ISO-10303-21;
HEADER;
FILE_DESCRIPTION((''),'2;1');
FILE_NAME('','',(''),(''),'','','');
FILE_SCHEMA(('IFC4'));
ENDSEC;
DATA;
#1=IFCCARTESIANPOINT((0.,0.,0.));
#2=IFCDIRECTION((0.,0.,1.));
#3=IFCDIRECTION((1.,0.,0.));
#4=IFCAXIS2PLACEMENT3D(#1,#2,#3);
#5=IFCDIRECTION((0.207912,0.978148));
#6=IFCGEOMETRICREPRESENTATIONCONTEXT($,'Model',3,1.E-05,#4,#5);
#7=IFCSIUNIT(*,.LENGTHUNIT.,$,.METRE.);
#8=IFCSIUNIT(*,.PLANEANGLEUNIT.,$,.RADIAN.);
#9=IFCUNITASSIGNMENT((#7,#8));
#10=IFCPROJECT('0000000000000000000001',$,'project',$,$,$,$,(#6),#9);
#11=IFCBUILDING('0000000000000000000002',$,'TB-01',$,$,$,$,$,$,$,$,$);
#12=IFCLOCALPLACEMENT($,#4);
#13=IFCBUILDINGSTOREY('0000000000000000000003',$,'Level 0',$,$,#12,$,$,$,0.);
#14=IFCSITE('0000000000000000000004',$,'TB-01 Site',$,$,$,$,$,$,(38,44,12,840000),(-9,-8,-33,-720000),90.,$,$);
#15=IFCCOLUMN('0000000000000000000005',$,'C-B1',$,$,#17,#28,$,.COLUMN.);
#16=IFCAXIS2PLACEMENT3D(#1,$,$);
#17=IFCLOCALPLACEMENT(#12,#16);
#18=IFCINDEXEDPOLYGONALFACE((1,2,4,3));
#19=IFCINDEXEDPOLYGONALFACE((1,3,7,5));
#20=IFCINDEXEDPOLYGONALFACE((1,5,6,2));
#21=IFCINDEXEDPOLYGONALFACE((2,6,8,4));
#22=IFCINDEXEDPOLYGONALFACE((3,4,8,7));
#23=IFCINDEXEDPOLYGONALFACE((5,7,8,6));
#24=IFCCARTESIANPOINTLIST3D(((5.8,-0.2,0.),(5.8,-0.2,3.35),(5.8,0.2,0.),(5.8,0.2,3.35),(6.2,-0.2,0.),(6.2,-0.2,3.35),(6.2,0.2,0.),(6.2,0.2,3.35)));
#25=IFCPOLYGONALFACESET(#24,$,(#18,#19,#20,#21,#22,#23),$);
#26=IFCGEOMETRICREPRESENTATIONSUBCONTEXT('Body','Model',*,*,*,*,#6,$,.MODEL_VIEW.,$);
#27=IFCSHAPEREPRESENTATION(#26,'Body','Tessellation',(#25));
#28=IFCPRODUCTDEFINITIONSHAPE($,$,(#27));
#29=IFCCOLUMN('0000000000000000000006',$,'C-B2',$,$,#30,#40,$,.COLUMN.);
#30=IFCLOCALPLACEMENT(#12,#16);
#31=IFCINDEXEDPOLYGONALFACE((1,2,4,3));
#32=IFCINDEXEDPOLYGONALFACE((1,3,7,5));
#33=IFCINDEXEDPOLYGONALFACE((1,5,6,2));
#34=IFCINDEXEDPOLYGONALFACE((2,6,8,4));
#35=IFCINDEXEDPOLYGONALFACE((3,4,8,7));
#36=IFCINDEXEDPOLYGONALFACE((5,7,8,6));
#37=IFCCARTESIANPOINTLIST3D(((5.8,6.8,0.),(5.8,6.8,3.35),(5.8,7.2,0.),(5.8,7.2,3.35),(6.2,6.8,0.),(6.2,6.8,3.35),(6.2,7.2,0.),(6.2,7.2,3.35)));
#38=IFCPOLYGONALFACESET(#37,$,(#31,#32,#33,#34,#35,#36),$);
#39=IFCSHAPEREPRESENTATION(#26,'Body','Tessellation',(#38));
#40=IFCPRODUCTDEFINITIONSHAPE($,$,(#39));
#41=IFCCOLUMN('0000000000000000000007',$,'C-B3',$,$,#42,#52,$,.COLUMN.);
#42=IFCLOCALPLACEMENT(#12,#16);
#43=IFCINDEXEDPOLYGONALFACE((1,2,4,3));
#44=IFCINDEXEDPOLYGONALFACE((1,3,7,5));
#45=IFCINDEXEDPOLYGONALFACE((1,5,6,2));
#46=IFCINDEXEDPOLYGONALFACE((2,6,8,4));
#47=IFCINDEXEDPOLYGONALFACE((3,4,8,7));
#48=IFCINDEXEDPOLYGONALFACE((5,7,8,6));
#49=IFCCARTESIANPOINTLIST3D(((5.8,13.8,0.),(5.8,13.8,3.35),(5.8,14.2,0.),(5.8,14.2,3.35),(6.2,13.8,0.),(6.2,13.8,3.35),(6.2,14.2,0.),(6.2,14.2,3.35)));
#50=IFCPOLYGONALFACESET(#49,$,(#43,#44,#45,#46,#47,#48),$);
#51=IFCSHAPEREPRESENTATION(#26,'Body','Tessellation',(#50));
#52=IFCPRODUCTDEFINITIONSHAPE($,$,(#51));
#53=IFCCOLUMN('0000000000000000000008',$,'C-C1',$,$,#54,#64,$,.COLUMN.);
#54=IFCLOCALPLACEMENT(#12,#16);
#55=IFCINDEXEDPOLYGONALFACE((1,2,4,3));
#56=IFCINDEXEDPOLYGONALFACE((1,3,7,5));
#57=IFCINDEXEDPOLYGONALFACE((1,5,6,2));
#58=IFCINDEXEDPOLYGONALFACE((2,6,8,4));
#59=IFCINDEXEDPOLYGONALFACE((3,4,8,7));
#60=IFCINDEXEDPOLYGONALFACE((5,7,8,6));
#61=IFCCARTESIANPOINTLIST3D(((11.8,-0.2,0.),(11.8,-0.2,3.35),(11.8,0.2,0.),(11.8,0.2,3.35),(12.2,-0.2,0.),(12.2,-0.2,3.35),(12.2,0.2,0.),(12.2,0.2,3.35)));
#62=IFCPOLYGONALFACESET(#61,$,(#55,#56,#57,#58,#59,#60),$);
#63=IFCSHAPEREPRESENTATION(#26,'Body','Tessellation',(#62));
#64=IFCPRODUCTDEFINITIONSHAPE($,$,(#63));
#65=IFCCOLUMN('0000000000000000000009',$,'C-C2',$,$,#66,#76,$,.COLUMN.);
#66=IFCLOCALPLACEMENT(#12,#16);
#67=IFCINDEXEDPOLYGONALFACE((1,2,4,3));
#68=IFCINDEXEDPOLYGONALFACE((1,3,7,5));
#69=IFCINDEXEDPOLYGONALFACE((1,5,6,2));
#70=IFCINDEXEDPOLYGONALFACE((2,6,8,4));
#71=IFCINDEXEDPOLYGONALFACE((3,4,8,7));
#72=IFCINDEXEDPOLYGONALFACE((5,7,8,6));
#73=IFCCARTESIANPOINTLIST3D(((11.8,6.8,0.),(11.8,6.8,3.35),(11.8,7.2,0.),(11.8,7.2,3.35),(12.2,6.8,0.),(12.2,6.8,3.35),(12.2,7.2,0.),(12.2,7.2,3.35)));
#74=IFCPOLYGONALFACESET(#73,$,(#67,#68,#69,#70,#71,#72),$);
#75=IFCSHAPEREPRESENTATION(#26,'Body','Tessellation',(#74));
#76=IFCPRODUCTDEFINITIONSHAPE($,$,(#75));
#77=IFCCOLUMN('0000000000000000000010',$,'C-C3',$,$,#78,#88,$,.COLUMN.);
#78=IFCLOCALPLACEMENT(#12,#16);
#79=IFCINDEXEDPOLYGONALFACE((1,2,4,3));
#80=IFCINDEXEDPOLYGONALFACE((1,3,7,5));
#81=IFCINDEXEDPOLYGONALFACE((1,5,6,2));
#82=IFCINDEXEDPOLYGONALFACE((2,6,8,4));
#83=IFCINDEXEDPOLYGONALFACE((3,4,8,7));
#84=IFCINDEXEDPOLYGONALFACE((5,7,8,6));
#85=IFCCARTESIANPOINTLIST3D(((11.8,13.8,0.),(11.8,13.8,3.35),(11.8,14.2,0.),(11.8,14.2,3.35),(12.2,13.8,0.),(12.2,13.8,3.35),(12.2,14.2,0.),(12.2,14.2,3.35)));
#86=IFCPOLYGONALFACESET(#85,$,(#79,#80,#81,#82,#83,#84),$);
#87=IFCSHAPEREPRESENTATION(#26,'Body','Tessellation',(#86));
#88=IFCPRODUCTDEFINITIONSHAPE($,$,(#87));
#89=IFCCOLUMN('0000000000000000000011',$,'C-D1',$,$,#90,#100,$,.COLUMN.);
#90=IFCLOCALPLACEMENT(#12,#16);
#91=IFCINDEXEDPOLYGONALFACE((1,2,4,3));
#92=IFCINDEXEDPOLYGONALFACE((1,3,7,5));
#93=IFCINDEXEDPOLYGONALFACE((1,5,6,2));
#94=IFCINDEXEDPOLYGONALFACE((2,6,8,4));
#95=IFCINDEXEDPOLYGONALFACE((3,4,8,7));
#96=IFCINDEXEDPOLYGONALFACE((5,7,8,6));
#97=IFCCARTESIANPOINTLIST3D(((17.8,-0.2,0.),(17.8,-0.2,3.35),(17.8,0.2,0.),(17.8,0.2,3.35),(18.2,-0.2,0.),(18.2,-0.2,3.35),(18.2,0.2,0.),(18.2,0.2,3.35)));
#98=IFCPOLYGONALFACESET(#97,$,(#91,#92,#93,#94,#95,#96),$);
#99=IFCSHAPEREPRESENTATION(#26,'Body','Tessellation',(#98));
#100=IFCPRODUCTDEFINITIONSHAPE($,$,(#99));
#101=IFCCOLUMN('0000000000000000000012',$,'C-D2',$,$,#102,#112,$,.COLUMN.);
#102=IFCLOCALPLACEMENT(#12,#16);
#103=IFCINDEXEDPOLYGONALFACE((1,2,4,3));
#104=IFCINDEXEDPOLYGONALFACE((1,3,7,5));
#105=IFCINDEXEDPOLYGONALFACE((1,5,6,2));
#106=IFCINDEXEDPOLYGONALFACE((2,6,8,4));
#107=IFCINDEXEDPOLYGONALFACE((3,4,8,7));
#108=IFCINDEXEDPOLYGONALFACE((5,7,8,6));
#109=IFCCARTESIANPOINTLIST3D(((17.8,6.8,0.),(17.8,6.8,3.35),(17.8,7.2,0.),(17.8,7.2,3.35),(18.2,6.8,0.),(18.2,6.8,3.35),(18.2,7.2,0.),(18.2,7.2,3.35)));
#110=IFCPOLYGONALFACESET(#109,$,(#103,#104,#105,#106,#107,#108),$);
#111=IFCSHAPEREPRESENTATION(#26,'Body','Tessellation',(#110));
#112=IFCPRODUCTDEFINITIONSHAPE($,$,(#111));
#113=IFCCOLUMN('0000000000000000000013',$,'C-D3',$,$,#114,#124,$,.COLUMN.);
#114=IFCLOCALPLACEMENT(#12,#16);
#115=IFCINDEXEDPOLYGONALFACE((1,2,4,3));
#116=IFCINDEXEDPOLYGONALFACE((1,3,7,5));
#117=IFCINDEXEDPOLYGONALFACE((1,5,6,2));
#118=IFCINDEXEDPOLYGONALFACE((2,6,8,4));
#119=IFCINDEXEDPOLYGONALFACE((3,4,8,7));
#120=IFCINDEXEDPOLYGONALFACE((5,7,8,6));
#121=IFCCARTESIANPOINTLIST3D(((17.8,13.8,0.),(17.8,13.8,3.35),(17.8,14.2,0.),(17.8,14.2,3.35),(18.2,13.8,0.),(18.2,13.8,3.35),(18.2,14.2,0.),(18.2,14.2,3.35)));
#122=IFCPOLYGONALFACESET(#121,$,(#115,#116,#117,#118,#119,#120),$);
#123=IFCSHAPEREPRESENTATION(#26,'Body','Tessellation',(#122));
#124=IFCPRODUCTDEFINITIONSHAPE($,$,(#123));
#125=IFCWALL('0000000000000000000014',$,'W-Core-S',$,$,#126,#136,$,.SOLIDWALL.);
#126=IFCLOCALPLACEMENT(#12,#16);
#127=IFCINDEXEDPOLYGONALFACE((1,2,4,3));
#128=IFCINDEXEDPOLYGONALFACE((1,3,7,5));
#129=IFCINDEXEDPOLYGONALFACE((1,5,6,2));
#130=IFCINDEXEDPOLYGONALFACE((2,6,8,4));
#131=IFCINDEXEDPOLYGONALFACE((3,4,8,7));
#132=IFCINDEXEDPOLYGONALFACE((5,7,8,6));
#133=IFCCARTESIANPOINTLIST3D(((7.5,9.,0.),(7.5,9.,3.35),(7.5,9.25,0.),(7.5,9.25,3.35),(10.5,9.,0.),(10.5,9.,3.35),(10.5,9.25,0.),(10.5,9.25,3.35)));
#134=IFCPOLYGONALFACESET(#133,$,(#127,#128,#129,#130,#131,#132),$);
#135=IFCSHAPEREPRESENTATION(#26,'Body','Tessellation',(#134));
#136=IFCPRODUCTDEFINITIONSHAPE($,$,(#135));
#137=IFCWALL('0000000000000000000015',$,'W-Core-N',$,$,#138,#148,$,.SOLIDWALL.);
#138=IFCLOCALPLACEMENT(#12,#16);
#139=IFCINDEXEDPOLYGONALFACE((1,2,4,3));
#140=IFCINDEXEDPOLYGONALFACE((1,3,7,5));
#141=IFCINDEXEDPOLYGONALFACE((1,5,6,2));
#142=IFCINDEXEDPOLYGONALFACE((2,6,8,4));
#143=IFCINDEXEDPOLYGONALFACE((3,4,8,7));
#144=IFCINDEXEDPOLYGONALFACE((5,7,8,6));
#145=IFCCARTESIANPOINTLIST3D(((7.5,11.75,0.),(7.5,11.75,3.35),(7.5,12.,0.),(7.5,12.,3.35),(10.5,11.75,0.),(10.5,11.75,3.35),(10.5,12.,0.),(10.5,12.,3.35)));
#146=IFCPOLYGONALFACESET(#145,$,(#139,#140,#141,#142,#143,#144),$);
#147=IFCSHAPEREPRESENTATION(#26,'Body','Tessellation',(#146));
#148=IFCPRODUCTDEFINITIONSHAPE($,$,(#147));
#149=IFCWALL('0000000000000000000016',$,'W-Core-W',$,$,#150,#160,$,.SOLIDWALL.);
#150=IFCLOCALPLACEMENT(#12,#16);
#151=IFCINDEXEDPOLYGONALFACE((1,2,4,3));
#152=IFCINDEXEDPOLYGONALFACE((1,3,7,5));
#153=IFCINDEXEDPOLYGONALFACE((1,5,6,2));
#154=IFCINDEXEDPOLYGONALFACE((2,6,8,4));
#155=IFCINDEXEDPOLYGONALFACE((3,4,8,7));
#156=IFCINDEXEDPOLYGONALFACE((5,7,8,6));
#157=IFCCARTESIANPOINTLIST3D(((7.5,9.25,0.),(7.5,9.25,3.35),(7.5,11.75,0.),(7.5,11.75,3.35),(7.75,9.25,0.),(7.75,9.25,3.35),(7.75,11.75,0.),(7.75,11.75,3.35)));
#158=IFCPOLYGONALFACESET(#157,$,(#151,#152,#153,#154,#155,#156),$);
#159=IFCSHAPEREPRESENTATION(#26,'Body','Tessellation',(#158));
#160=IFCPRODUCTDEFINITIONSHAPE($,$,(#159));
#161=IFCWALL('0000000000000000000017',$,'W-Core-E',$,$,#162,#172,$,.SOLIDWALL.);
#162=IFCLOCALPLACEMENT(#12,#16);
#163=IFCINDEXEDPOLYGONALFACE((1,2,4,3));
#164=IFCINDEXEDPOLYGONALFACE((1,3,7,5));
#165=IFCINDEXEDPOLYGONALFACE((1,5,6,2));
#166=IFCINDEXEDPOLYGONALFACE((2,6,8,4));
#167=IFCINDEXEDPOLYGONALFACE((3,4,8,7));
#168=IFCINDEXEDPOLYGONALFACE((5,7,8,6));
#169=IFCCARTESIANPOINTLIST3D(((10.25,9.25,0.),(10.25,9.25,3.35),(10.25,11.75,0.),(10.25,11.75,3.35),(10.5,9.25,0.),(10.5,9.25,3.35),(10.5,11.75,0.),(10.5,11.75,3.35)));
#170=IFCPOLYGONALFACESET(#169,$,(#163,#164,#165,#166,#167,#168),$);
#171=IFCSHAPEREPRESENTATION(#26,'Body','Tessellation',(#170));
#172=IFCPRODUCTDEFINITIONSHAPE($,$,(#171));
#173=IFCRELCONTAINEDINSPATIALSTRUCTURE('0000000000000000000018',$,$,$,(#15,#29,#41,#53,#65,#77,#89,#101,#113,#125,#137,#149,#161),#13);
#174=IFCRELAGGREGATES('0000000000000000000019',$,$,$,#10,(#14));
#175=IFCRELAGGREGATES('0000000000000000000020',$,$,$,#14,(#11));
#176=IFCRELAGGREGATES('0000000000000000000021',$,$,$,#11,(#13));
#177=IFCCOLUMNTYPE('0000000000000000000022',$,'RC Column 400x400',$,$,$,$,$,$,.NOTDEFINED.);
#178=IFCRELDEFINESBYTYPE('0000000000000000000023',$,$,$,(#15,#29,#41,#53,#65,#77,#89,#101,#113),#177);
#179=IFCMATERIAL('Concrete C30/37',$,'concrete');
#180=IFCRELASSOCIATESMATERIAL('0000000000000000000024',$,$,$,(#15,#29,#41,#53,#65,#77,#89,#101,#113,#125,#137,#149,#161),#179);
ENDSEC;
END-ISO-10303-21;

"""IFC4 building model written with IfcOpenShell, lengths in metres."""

from ifc_helpers import new_model, si_unit, direction, frame, origin_with_axes, place, context, subcontext, project, spatial, rectangle, extrude, material, type_object, element, save


model = new_model("IFC4")

# Units and contexts
model_context = context("Model", 3, precision=1e-05, world=origin_with_axes(), true_north=direction((0.207912, 0.978148)))
body_context = subcontext(model_context, "Body", "Model", "MODEL_VIEW")
ifc_project = project(units=[si_unit("LENGTHUNIT", "METRE"), si_unit("PLANEANGLEUNIT", "RADIAN")], contexts=[model_context])

# Site, building, storey
site = spatial("IfcSite", under=ifc_project, Name="TB-01 Site", RefLatitude=(38, 44, 12, 840000), RefLongitude=(-9, -8, -33, -720000), RefElevation=90.0)
building = spatial("IfcBuilding", under=site, Name="TB-01")
storey_placement = place(None, origin_with_axes())
storey = spatial("IfcBuildingStorey", under=building, at=storey_placement, Name="Level 0", Elevation=0.0)

# Columns
ifc_material_1 = material(Name="Concrete C30/37", Category="concrete")
column_type = type_object("IfcColumnType", Name="RC Column 400x400", PredefinedType="NOTDEFINED")
column_1_placement = place(storey_placement, frame((6.0, 0.0, 0.0), z_axis=(0.0, 0.0, 1.0), x_axis=(1.0, 0.0, 0.0)))
element("IfcColumn", 1, at=column_1_placement, inside=storey, type_object=column_type, material=ifc_material_1, Name="C-B1", PredefinedType="COLUMN", context=body_context, shape_type="SweptSolid", body=[
    extrude(rectangle(XDim=0.4, YDim=0.4), origin_with_axes(), (0.0, 0.0, 1.0), 3.35),
])
column_2_placement = place(storey_placement, frame((6.0, 7.0, 0.0), z_axis=(0.0, 0.0, 1.0), x_axis=(1.0, 0.0, 0.0)))
element("IfcColumn", 2, at=column_2_placement, inside=storey, type_object=column_type, material=ifc_material_1, Name="C-B2", PredefinedType="COLUMN", context=body_context, shape_type="SweptSolid", body=[
    extrude(rectangle(XDim=0.4, YDim=0.4), origin_with_axes(), (0.0, 0.0, 1.0), 3.35),
])
column_3_placement = place(storey_placement, frame((6.0, 14.0, 0.0), z_axis=(0.0, 0.0, 1.0), x_axis=(1.0, 0.0, 0.0)))
element("IfcColumn", 3, at=column_3_placement, inside=storey, type_object=column_type, material=ifc_material_1, Name="C-B3", PredefinedType="COLUMN", context=body_context, shape_type="SweptSolid", body=[
    extrude(rectangle(XDim=0.4, YDim=0.4), origin_with_axes(), (0.0, 0.0, 1.0), 3.35),
])
column_4_placement = place(storey_placement, frame((12.0, 0.0, 0.0), z_axis=(0.0, 0.0, 1.0), x_axis=(1.0, 0.0, 0.0)))
element("IfcColumn", 4, at=column_4_placement, inside=storey, type_object=column_type, material=ifc_material_1, Name="C-C1", PredefinedType="COLUMN", context=body_context, shape_type="SweptSolid", body=[
    extrude(rectangle(XDim=0.4, YDim=0.4), origin_with_axes(), (0.0, 0.0, 1.0), 3.35),
])
column_5_placement = place(storey_placement, frame((12.0, 7.0, 0.0), z_axis=(0.0, 0.0, 1.0), x_axis=(1.0, 0.0, 0.0)))
element("IfcColumn", 5, at=column_5_placement, inside=storey, type_object=column_type, material=ifc_material_1, Name="C-C2", PredefinedType="COLUMN", context=body_context, shape_type="SweptSolid", body=[
    extrude(rectangle(XDim=0.4, YDim=0.4), origin_with_axes(), (0.0, 0.0, 1.0), 3.35),
])
column_6_placement = place(storey_placement, frame((12.0, 14.0, 0.0), z_axis=(0.0, 0.0, 1.0), x_axis=(1.0, 0.0, 0.0)))
element("IfcColumn", 6, at=column_6_placement, inside=storey, type_object=column_type, material=ifc_material_1, Name="C-C3", PredefinedType="COLUMN", context=body_context, shape_type="SweptSolid", body=[
    extrude(rectangle(XDim=0.4, YDim=0.4), origin_with_axes(), (0.0, 0.0, 1.0), 3.35),
])
column_7_placement = place(storey_placement, frame((18.0, 0.0, 0.0), z_axis=(0.0, 0.0, 1.0), x_axis=(1.0, 0.0, 0.0)))
element("IfcColumn", 7, at=column_7_placement, inside=storey, type_object=column_type, material=ifc_material_1, Name="C-D1", PredefinedType="COLUMN", context=body_context, shape_type="SweptSolid", body=[
    extrude(rectangle(XDim=0.4, YDim=0.4), origin_with_axes(), (0.0, 0.0, 1.0), 3.35),
])
column_8_placement = place(storey_placement, frame((18.0, 7.0, 0.0), z_axis=(0.0, 0.0, 1.0), x_axis=(1.0, 0.0, 0.0)))
element("IfcColumn", 8, at=column_8_placement, inside=storey, type_object=column_type, material=ifc_material_1, Name="C-D2", PredefinedType="COLUMN", context=body_context, shape_type="SweptSolid", body=[
    extrude(rectangle(XDim=0.4, YDim=0.4), origin_with_axes(), (0.0, 0.0, 1.0), 3.35),
])
column_9_placement = place(storey_placement, frame((18.0, 14.0, 0.0), z_axis=(0.0, 0.0, 1.0), x_axis=(1.0, 0.0, 0.0)))
element("IfcColumn", 9, at=column_9_placement, inside=storey, type_object=column_type, material=ifc_material_1, Name="C-D3", PredefinedType="COLUMN", context=body_context, shape_type="SweptSolid", body=[
    extrude(rectangle(XDim=0.4, YDim=0.4), origin_with_axes(), (0.0, 0.0, 1.0), 3.35),
])

# Walls
for number, where, z_axis, x_axis, name in (
    (10, (9.0, 9.125, 0.0), (0.0, 0.0, 1.0), (1.0, 0.0, 0.0), "W-Core-S"),
    (11, (9.0, 11.875, 0.0), (0.0, 0.0, 1.0), (1.0, 0.0, 0.0), "W-Core-N"),
):
    element("IfcWall", number, at=place(storey_placement, frame(where, z_axis=z_axis, x_axis=x_axis)), inside=storey, material=ifc_material_1, Name=name, PredefinedType="SOLIDWALL", context=body_context, shape_type="SweptSolid", body=[
        extrude(rectangle(XDim=3.0, YDim=0.25), origin_with_axes(), (0.0, 0.0, 1.0), 3.35),
    ])
for number, where, z_axis, x_axis, name in (
    (12, (7.625, 10.5, 0.0), (0.0, 0.0, 1.0), (1.0, 0.0, 0.0), "W-Core-W"),
    (13, (10.375, 10.5, 0.0), (0.0, 0.0, 1.0), (1.0, 0.0, 0.0), "W-Core-E"),
):
    element("IfcWall", number, at=place(storey_placement, frame(where, z_axis=z_axis, x_axis=x_axis)), inside=storey, material=ifc_material_1, Name=name, PredefinedType="SOLIDWALL", context=body_context, shape_type="SweptSolid", body=[
        extrude(rectangle(XDim=0.25, YDim=2.5), origin_with_axes(), (0.0, 0.0, 1.0), 3.35),
    ])

save(model, "model.ifc")
